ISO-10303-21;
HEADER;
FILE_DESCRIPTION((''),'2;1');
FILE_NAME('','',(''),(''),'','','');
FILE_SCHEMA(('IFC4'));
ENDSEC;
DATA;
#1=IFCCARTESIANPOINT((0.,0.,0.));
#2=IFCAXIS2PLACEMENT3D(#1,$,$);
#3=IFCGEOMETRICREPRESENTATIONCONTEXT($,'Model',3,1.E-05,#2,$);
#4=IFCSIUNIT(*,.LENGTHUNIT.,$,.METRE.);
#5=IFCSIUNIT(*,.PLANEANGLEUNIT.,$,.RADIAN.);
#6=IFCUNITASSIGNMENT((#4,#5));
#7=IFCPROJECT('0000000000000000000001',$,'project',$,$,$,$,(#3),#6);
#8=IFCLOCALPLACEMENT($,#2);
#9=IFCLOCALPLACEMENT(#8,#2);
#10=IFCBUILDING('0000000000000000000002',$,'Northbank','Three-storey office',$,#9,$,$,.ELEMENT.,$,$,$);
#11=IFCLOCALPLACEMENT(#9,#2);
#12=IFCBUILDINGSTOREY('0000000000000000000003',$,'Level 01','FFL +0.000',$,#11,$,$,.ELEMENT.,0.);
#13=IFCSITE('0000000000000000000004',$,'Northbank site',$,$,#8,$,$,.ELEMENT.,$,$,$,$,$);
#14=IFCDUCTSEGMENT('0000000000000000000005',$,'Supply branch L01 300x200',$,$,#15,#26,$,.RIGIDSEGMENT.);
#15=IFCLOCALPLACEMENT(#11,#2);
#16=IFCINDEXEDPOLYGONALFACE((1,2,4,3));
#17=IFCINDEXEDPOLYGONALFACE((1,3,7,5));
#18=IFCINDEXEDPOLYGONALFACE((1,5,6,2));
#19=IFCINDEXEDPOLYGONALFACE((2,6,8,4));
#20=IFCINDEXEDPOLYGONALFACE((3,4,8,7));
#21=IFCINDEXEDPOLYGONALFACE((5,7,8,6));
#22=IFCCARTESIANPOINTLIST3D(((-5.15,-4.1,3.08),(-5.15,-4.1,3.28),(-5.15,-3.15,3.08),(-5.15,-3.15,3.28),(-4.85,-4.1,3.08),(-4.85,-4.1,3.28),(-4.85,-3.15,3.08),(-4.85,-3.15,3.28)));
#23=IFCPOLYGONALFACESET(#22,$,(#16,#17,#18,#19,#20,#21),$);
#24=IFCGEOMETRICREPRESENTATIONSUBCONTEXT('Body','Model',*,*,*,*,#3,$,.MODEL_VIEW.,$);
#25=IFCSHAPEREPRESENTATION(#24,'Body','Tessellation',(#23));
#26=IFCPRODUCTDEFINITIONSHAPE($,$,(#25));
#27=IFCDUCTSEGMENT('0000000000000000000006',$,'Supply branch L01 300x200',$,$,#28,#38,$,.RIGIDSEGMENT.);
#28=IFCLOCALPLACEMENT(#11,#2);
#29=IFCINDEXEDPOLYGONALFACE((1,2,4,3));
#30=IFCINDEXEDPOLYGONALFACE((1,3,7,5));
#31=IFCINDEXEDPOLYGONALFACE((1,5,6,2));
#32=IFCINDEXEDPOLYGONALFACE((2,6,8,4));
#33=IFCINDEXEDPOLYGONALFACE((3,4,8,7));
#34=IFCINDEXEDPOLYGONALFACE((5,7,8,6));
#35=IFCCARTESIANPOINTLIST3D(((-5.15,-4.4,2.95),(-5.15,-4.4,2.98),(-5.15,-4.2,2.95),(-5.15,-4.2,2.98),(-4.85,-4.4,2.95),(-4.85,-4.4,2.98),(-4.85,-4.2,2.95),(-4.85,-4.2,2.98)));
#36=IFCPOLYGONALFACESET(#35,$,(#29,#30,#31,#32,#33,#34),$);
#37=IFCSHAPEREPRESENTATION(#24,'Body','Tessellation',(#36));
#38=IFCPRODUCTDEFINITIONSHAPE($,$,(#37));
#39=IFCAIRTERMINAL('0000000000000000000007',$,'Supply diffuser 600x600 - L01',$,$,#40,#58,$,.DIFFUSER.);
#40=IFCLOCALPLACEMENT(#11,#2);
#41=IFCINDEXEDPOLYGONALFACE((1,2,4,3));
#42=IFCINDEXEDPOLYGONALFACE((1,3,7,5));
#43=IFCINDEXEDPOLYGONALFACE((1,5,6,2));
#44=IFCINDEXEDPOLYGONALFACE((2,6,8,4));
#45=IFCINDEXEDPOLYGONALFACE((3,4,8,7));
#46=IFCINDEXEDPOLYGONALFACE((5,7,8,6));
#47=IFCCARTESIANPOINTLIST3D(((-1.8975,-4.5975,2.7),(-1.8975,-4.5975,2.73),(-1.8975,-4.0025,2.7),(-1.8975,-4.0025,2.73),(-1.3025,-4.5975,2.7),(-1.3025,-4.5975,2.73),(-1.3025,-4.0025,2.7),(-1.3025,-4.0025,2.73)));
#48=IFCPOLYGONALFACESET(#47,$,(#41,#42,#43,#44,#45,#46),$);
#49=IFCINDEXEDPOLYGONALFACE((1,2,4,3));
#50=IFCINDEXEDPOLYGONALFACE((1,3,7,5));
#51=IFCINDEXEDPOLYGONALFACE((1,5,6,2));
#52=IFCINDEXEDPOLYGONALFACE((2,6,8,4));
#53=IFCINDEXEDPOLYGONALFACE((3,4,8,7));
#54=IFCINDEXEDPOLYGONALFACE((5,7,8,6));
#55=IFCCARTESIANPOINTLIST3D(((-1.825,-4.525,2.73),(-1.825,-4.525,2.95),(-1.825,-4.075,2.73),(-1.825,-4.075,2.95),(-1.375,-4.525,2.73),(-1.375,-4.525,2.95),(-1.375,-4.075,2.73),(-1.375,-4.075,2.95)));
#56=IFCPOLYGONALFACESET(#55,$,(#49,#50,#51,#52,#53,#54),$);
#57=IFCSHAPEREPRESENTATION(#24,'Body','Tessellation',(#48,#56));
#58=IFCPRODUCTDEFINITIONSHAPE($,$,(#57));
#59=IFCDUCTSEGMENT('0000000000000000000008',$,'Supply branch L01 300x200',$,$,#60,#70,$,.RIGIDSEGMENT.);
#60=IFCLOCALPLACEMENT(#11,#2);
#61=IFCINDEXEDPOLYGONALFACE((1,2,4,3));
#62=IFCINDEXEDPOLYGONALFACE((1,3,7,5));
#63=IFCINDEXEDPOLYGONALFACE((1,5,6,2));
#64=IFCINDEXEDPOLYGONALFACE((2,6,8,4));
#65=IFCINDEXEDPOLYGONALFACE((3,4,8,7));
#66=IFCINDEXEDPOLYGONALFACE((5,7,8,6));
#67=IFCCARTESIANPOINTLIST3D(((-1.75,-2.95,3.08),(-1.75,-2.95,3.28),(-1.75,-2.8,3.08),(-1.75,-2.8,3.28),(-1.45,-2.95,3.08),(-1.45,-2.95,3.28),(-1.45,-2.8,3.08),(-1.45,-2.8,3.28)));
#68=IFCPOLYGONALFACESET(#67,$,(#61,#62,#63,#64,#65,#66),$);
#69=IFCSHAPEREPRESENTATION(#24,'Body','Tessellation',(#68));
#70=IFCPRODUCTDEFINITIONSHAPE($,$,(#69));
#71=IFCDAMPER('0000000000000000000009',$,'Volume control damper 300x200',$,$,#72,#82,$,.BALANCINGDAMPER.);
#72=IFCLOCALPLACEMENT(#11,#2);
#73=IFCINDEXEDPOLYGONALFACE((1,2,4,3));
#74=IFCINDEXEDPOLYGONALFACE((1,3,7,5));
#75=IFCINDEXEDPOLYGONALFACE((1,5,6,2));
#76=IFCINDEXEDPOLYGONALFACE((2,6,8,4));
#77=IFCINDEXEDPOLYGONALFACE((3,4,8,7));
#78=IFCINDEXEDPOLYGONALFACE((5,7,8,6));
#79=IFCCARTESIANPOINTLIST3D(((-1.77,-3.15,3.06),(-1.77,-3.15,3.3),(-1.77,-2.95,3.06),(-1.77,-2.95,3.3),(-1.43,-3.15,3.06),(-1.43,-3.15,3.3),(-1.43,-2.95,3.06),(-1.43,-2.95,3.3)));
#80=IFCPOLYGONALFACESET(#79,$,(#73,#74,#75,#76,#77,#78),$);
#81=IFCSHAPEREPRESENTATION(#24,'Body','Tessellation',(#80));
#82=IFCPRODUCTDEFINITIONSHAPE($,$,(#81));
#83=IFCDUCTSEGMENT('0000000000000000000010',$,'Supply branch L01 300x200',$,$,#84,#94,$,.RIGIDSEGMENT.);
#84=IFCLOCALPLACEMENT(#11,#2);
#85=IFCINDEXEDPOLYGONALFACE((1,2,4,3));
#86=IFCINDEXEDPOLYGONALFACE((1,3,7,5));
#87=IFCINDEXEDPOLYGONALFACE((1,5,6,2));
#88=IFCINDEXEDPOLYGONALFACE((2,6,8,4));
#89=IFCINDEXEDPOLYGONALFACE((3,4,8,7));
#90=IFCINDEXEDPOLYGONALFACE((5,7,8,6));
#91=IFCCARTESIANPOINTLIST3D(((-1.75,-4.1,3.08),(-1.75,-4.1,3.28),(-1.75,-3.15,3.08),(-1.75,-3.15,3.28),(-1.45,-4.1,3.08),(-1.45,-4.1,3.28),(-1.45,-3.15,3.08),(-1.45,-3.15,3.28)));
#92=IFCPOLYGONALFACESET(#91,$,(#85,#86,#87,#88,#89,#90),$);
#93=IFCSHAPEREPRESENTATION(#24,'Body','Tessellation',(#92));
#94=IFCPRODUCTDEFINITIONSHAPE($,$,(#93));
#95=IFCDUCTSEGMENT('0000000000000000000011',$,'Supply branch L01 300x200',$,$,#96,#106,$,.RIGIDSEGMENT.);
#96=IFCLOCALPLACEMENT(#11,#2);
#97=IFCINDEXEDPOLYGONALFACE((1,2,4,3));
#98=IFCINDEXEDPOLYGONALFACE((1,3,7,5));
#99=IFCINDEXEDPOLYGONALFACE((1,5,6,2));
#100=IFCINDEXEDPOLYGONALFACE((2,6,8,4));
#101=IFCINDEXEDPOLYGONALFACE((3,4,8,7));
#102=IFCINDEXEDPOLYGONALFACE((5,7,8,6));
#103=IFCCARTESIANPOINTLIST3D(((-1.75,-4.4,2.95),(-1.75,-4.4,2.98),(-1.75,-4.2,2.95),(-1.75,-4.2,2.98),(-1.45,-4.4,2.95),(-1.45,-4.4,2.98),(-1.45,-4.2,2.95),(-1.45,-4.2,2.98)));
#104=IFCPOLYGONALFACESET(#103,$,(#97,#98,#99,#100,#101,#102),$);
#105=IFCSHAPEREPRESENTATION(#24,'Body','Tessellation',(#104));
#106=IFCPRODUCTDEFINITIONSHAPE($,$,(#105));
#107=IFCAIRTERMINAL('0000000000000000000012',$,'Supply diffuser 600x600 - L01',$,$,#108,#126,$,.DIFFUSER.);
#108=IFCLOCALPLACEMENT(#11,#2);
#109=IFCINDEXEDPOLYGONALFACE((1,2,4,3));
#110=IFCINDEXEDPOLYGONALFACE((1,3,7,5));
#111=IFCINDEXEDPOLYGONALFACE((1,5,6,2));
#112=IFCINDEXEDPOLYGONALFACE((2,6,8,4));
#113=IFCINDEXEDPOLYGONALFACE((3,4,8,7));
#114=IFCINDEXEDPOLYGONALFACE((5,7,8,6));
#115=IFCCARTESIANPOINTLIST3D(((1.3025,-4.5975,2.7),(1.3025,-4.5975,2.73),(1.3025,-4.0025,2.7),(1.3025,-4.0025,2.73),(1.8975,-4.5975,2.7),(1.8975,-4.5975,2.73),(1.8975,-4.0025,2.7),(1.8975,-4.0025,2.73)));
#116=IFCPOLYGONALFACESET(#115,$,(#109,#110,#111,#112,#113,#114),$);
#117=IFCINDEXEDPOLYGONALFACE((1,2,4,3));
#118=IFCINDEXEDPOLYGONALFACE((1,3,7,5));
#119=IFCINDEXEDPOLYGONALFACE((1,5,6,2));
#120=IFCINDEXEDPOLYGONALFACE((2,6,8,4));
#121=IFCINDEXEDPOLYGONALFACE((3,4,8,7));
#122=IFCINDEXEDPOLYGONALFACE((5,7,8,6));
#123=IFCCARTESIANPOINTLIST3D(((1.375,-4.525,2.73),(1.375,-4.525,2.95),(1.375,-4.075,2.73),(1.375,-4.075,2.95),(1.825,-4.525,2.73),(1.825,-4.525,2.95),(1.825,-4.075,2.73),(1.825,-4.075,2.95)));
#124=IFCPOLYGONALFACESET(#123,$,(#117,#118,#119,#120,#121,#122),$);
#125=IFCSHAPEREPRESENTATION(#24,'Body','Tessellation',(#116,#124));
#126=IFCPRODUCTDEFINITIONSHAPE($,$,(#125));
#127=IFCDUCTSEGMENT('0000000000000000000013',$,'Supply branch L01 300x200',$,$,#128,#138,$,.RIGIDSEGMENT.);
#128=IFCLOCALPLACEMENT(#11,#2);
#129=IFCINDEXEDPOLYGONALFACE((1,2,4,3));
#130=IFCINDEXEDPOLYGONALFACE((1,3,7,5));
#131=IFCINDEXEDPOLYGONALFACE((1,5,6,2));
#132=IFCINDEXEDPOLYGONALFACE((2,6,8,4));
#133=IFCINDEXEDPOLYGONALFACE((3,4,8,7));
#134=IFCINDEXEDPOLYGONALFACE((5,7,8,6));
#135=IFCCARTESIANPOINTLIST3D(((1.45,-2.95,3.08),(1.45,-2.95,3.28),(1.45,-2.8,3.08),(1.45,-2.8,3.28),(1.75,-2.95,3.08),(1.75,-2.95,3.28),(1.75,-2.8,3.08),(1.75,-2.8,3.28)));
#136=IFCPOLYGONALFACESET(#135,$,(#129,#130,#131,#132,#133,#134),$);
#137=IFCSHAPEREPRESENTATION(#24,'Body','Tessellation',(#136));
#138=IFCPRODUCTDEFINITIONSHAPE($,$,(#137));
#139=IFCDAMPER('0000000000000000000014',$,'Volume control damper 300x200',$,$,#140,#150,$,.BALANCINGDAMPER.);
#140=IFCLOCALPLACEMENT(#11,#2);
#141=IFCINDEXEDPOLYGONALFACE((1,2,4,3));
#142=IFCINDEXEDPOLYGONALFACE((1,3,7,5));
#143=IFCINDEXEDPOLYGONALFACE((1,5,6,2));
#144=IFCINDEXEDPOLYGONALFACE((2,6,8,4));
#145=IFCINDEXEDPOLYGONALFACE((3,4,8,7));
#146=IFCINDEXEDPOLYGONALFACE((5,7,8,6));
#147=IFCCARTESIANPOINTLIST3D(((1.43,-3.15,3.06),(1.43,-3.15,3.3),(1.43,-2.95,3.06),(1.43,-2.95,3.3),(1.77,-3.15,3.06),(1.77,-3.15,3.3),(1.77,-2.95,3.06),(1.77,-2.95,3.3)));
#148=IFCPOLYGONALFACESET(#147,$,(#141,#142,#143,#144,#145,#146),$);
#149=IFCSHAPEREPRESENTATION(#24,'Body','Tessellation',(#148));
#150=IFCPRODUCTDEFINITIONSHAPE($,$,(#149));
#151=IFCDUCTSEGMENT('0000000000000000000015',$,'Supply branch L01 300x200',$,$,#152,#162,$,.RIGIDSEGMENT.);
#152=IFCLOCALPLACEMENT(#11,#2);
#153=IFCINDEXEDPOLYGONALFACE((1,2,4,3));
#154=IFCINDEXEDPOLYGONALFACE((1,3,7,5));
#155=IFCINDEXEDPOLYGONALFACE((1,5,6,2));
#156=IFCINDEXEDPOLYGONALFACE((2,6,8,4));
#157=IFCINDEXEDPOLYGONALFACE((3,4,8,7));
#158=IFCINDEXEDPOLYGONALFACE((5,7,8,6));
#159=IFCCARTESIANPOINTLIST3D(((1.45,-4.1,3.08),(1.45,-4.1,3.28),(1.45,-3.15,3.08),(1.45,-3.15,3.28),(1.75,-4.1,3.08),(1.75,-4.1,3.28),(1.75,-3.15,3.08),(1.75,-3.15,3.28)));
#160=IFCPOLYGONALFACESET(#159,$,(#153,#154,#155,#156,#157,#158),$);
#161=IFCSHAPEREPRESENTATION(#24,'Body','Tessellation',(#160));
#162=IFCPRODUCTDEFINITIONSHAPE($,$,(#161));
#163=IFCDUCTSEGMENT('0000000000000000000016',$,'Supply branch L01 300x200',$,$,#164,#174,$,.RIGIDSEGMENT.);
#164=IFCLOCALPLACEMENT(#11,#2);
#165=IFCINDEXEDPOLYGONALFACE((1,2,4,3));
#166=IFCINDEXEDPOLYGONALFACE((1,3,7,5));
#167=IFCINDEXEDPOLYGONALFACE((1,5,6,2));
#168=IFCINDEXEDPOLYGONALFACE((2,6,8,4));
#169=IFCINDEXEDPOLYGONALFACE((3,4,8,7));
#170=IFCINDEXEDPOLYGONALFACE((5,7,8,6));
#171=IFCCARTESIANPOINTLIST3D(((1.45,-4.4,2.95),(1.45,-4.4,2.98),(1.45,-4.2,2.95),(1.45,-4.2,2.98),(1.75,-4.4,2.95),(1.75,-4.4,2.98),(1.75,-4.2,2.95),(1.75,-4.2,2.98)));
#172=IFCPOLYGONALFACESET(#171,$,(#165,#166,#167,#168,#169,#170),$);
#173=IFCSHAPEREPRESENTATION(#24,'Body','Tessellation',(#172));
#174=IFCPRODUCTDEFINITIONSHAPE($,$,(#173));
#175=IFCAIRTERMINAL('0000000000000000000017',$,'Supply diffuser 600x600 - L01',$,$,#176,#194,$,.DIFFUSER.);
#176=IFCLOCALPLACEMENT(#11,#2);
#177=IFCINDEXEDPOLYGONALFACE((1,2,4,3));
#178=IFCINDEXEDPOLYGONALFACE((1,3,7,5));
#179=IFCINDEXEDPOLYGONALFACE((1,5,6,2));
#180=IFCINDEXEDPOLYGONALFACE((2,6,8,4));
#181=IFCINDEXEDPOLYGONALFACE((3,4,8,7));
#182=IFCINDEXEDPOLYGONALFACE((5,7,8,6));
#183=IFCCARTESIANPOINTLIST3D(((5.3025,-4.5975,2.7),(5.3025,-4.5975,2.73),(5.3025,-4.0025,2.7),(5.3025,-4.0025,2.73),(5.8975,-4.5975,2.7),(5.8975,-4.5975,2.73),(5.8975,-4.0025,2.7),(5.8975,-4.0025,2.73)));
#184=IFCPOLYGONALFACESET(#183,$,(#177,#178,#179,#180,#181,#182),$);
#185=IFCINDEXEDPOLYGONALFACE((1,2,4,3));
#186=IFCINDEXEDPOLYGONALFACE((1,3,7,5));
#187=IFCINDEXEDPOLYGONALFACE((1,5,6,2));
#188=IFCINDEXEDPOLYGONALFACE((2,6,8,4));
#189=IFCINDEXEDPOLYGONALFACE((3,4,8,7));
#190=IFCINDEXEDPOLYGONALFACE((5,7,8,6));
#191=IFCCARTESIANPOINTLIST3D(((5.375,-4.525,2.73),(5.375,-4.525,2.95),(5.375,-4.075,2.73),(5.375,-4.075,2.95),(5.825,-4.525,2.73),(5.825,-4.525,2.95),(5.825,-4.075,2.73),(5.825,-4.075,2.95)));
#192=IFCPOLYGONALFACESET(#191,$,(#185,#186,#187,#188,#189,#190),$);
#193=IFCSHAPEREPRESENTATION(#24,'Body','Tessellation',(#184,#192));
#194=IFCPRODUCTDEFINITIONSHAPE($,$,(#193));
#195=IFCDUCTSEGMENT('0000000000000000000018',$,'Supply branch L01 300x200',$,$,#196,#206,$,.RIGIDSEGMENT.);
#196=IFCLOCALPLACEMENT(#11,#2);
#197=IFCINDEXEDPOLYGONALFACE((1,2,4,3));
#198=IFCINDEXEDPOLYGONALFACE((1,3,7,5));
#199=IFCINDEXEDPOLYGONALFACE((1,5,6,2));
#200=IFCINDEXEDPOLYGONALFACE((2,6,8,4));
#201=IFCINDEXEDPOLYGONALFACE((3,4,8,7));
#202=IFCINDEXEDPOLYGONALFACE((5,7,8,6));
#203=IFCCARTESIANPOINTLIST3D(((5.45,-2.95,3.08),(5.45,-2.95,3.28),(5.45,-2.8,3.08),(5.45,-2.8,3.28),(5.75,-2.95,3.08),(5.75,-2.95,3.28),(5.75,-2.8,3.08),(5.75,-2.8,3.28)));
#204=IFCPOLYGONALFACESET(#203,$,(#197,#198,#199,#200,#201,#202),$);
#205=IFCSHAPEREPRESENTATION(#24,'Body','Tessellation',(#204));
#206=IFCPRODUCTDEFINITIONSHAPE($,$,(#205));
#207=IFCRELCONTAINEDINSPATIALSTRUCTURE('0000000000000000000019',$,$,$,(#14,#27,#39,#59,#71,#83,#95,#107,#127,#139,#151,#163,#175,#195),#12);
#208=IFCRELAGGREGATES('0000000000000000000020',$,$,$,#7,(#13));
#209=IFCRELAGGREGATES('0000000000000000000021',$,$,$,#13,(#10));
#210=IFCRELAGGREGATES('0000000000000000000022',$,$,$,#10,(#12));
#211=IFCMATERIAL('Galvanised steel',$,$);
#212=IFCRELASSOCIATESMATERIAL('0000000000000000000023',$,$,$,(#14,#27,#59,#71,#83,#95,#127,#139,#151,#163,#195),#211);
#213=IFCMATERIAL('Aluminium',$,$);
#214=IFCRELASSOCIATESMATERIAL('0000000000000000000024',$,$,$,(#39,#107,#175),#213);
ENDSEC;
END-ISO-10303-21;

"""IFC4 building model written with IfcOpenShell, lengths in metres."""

from ifc_helpers import new_model, si_unit, frame, origin, place, context, subcontext, project, spatial, rectangle, extrude, material, element, save


model = new_model("IFC4")

# Units and contexts
model_context = context("Model", 3, precision=1e-05, world=origin())
body_context = subcontext(model_context, "Body", "Model", "MODEL_VIEW")
ifc_project = project(units=[si_unit("LENGTHUNIT", "METRE"), si_unit("PLANEANGLEUNIT", "RADIAN")], contexts=[model_context])

# Site, building, storey
site_placement = place(None, origin())
site = spatial("IfcSite", under=ifc_project, at=site_placement, Name="Northbank site", CompositionType="ELEMENT")
building_placement = place(site_placement, origin())
building = spatial("IfcBuilding", under=site, at=building_placement, Name="Northbank", Description="Three-storey office", CompositionType="ELEMENT")
storey_placement = place(building_placement, origin())
storey = spatial("IfcBuildingStorey", under=building, at=storey_placement, Name="Level 01", Description="FFL +0.000", CompositionType="ELEMENT", Elevation=0.0)

# Duct segments
ifc_material_1 = material(Name="Galvanised steel")
duct_segment_1_placement = place(storey_placement, origin())
element("IfcDuctSegment", 1, at=duct_segment_1_placement, inside=storey, material=ifc_material_1, Name="Supply branch L01 300x200", PredefinedType="RIGIDSEGMENT", context=body_context, shape_type="SweptSolid", body=[
    extrude(rectangle(XDim=0.3, YDim=0.2), frame((-5.0, -3.15, 3.18), z_axis=(0.0, -1.0, 0.0), x_axis=(1.0, 0.0, 0.0)), (0.0, 0.0, 1.0), 0.95),
])
duct_segment_2_placement = place(storey_placement, origin())
element("IfcDuctSegment", 2, at=duct_segment_2_placement, inside=storey, material=ifc_material_1, Name="Supply branch L01 300x200", PredefinedType="RIGIDSEGMENT", context=body_context, shape_type="SweptSolid", body=[
    extrude(rectangle(XDim=0.3, YDim=0.2), frame((-5.0, -4.3, 2.98), z_axis=(0.0, 0.0, -1.0), x_axis=(1.0, 0.0, 0.0)), (0.0, 0.0, 1.0), 0.03),
])

# Air terminal
ifc_material_2 = material(Name="Aluminium")
air_terminal_1_placement = place(storey_placement, origin())
element("IfcAirTerminal", 3, at=air_terminal_1_placement, inside=storey, material=ifc_material_2, Name="Supply diffuser 600x600 - L01", PredefinedType="DIFFUSER", context=body_context, shape_type="SweptSolid", body=[
    extrude(rectangle(XDim=0.595, YDim=0.595), frame((-1.6, -4.3, 2.7)), (0.0, 0.0, 1.0), 0.03),
    extrude(rectangle(XDim=0.45, YDim=0.45), frame((-1.6, -4.3, 2.73)), (0.0, 0.0, 1.0), 0.22),
])

# Duct segment
duct_segment_3_placement = place(storey_placement, origin())
element("IfcDuctSegment", 4, at=duct_segment_3_placement, inside=storey, material=ifc_material_1, Name="Supply branch L01 300x200", PredefinedType="RIGIDSEGMENT", context=body_context, shape_type="SweptSolid", body=[
    extrude(rectangle(XDim=0.3, YDim=0.2), frame((-1.6, -2.8, 3.18), z_axis=(0.0, -1.0, 0.0), x_axis=(1.0, 0.0, 0.0)), (0.0, 0.0, 1.0), 0.15),
])

# Damper
damper_1_placement = place(storey_placement, origin())
element("IfcDamper", 5, at=damper_1_placement, inside=storey, material=ifc_material_1, Name="Volume control damper 300x200", PredefinedType="BALANCINGDAMPER", context=body_context, shape_type="SweptSolid", body=[
    extrude(rectangle(XDim=0.34, YDim=0.24), frame((-1.6, -2.95, 3.18), z_axis=(0.0, -1.0, 0.0), x_axis=(1.0, 0.0, 0.0)), (0.0, 0.0, 1.0), 0.2),
])

# Duct segments
duct_segment_4_placement = place(storey_placement, origin())
element("IfcDuctSegment", 6, at=duct_segment_4_placement, inside=storey, material=ifc_material_1, Name="Supply branch L01 300x200", PredefinedType="RIGIDSEGMENT", context=body_context, shape_type="SweptSolid", body=[
    extrude(rectangle(XDim=0.3, YDim=0.2), frame((-1.6, -3.15, 3.18), z_axis=(0.0, -1.0, 0.0), x_axis=(1.0, 0.0, 0.0)), (0.0, 0.0, 1.0), 0.95),
])
duct_segment_5_placement = place(storey_placement, origin())
element("IfcDuctSegment", 7, at=duct_segment_5_placement, inside=storey, material=ifc_material_1, Name="Supply branch L01 300x200", PredefinedType="RIGIDSEGMENT", context=body_context, shape_type="SweptSolid", body=[
    extrude(rectangle(XDim=0.3, YDim=0.2), frame((-1.6, -4.3, 2.98), z_axis=(0.0, 0.0, -1.0), x_axis=(1.0, 0.0, 0.0)), (0.0, 0.0, 1.0), 0.03),
])

# Air terminal
air_terminal_2_placement = place(storey_placement, origin())
element("IfcAirTerminal", 8, at=air_terminal_2_placement, inside=storey, material=ifc_material_2, Name="Supply diffuser 600x600 - L01", PredefinedType="DIFFUSER", context=body_context, shape_type="SweptSolid", body=[
    extrude(rectangle(XDim=0.595, YDim=0.595), frame((1.6, -4.3, 2.7)), (0.0, 0.0, 1.0), 0.03),
    extrude(rectangle(XDim=0.45, YDim=0.45), frame((1.6, -4.3, 2.73)), (0.0, 0.0, 1.0), 0.22),
])

# Duct segment
duct_segment_6_placement = place(storey_placement, origin())
element("IfcDuctSegment", 9, at=duct_segment_6_placement, inside=storey, material=ifc_material_1, Name="Supply branch L01 300x200", PredefinedType="RIGIDSEGMENT", context=body_context, shape_type="SweptSolid", body=[
    extrude(rectangle(XDim=0.3, YDim=0.2), frame((1.6, -2.8, 3.18), z_axis=(0.0, -1.0, 0.0), x_axis=(1.0, 0.0, 0.0)), (0.0, 0.0, 1.0), 0.15),
])

# Damper
damper_2_placement = place(storey_placement, origin())
element("IfcDamper", 10, at=damper_2_placement, inside=storey, material=ifc_material_1, Name="Volume control damper 300x200", PredefinedType="BALANCINGDAMPER", context=body_context, shape_type="SweptSolid", body=[
    extrude(rectangle(XDim=0.34, YDim=0.24), frame((1.6, -2.95, 3.18), z_axis=(0.0, -1.0, 0.0), x_axis=(1.0, 0.0, 0.0)), (0.0, 0.0, 1.0), 0.2),
])

# Duct segments
duct_segment_7_placement = place(storey_placement, origin())
element("IfcDuctSegment", 11, at=duct_segment_7_placement, inside=storey, material=ifc_material_1, Name="Supply branch L01 300x200", PredefinedType="RIGIDSEGMENT", context=body_context, shape_type="SweptSolid", body=[
    extrude(rectangle(XDim=0.3, YDim=0.2), frame((1.6, -3.15, 3.18), z_axis=(0.0, -1.0, 0.0), x_axis=(1.0, 0.0, 0.0)), (0.0, 0.0, 1.0), 0.95),
])
duct_segment_8_placement = place(storey_placement, origin())
element("IfcDuctSegment", 12, at=duct_segment_8_placement, inside=storey, material=ifc_material_1, Name="Supply branch L01 300x200", PredefinedType="RIGIDSEGMENT", context=body_context, shape_type="SweptSolid", body=[
    extrude(rectangle(XDim=0.3, YDim=0.2), frame((1.6, -4.3, 2.98), z_axis=(0.0, 0.0, -1.0), x_axis=(1.0, 0.0, 0.0)), (0.0, 0.0, 1.0), 0.03),
])

# Air terminal
air_terminal_3_placement = place(storey_placement, origin())
element("IfcAirTerminal", 13, at=air_terminal_3_placement, inside=storey, material=ifc_material_2, Name="Supply diffuser 600x600 - L01", PredefinedType="DIFFUSER", context=body_context, shape_type="SweptSolid", body=[
    extrude(rectangle(XDim=0.595, YDim=0.595), frame((5.6, -4.3, 2.7)), (0.0, 0.0, 1.0), 0.03),
    extrude(rectangle(XDim=0.45, YDim=0.45), frame((5.6, -4.3, 2.73)), (0.0, 0.0, 1.0), 0.22),
])

# Duct segment
duct_segment_9_placement = place(storey_placement, origin())
element("IfcDuctSegment", 14, at=duct_segment_9_placement, inside=storey, material=ifc_material_1, Name="Supply branch L01 300x200", PredefinedType="RIGIDSEGMENT", context=body_context, shape_type="SweptSolid", body=[
    extrude(rectangle(XDim=0.3, YDim=0.2), frame((5.6, -2.8, 3.18), z_axis=(0.0, -1.0, 0.0), x_axis=(1.0, 0.0, 0.0)), (0.0, 0.0, 1.0), 0.15),
])

save(model, "model.ifc")
